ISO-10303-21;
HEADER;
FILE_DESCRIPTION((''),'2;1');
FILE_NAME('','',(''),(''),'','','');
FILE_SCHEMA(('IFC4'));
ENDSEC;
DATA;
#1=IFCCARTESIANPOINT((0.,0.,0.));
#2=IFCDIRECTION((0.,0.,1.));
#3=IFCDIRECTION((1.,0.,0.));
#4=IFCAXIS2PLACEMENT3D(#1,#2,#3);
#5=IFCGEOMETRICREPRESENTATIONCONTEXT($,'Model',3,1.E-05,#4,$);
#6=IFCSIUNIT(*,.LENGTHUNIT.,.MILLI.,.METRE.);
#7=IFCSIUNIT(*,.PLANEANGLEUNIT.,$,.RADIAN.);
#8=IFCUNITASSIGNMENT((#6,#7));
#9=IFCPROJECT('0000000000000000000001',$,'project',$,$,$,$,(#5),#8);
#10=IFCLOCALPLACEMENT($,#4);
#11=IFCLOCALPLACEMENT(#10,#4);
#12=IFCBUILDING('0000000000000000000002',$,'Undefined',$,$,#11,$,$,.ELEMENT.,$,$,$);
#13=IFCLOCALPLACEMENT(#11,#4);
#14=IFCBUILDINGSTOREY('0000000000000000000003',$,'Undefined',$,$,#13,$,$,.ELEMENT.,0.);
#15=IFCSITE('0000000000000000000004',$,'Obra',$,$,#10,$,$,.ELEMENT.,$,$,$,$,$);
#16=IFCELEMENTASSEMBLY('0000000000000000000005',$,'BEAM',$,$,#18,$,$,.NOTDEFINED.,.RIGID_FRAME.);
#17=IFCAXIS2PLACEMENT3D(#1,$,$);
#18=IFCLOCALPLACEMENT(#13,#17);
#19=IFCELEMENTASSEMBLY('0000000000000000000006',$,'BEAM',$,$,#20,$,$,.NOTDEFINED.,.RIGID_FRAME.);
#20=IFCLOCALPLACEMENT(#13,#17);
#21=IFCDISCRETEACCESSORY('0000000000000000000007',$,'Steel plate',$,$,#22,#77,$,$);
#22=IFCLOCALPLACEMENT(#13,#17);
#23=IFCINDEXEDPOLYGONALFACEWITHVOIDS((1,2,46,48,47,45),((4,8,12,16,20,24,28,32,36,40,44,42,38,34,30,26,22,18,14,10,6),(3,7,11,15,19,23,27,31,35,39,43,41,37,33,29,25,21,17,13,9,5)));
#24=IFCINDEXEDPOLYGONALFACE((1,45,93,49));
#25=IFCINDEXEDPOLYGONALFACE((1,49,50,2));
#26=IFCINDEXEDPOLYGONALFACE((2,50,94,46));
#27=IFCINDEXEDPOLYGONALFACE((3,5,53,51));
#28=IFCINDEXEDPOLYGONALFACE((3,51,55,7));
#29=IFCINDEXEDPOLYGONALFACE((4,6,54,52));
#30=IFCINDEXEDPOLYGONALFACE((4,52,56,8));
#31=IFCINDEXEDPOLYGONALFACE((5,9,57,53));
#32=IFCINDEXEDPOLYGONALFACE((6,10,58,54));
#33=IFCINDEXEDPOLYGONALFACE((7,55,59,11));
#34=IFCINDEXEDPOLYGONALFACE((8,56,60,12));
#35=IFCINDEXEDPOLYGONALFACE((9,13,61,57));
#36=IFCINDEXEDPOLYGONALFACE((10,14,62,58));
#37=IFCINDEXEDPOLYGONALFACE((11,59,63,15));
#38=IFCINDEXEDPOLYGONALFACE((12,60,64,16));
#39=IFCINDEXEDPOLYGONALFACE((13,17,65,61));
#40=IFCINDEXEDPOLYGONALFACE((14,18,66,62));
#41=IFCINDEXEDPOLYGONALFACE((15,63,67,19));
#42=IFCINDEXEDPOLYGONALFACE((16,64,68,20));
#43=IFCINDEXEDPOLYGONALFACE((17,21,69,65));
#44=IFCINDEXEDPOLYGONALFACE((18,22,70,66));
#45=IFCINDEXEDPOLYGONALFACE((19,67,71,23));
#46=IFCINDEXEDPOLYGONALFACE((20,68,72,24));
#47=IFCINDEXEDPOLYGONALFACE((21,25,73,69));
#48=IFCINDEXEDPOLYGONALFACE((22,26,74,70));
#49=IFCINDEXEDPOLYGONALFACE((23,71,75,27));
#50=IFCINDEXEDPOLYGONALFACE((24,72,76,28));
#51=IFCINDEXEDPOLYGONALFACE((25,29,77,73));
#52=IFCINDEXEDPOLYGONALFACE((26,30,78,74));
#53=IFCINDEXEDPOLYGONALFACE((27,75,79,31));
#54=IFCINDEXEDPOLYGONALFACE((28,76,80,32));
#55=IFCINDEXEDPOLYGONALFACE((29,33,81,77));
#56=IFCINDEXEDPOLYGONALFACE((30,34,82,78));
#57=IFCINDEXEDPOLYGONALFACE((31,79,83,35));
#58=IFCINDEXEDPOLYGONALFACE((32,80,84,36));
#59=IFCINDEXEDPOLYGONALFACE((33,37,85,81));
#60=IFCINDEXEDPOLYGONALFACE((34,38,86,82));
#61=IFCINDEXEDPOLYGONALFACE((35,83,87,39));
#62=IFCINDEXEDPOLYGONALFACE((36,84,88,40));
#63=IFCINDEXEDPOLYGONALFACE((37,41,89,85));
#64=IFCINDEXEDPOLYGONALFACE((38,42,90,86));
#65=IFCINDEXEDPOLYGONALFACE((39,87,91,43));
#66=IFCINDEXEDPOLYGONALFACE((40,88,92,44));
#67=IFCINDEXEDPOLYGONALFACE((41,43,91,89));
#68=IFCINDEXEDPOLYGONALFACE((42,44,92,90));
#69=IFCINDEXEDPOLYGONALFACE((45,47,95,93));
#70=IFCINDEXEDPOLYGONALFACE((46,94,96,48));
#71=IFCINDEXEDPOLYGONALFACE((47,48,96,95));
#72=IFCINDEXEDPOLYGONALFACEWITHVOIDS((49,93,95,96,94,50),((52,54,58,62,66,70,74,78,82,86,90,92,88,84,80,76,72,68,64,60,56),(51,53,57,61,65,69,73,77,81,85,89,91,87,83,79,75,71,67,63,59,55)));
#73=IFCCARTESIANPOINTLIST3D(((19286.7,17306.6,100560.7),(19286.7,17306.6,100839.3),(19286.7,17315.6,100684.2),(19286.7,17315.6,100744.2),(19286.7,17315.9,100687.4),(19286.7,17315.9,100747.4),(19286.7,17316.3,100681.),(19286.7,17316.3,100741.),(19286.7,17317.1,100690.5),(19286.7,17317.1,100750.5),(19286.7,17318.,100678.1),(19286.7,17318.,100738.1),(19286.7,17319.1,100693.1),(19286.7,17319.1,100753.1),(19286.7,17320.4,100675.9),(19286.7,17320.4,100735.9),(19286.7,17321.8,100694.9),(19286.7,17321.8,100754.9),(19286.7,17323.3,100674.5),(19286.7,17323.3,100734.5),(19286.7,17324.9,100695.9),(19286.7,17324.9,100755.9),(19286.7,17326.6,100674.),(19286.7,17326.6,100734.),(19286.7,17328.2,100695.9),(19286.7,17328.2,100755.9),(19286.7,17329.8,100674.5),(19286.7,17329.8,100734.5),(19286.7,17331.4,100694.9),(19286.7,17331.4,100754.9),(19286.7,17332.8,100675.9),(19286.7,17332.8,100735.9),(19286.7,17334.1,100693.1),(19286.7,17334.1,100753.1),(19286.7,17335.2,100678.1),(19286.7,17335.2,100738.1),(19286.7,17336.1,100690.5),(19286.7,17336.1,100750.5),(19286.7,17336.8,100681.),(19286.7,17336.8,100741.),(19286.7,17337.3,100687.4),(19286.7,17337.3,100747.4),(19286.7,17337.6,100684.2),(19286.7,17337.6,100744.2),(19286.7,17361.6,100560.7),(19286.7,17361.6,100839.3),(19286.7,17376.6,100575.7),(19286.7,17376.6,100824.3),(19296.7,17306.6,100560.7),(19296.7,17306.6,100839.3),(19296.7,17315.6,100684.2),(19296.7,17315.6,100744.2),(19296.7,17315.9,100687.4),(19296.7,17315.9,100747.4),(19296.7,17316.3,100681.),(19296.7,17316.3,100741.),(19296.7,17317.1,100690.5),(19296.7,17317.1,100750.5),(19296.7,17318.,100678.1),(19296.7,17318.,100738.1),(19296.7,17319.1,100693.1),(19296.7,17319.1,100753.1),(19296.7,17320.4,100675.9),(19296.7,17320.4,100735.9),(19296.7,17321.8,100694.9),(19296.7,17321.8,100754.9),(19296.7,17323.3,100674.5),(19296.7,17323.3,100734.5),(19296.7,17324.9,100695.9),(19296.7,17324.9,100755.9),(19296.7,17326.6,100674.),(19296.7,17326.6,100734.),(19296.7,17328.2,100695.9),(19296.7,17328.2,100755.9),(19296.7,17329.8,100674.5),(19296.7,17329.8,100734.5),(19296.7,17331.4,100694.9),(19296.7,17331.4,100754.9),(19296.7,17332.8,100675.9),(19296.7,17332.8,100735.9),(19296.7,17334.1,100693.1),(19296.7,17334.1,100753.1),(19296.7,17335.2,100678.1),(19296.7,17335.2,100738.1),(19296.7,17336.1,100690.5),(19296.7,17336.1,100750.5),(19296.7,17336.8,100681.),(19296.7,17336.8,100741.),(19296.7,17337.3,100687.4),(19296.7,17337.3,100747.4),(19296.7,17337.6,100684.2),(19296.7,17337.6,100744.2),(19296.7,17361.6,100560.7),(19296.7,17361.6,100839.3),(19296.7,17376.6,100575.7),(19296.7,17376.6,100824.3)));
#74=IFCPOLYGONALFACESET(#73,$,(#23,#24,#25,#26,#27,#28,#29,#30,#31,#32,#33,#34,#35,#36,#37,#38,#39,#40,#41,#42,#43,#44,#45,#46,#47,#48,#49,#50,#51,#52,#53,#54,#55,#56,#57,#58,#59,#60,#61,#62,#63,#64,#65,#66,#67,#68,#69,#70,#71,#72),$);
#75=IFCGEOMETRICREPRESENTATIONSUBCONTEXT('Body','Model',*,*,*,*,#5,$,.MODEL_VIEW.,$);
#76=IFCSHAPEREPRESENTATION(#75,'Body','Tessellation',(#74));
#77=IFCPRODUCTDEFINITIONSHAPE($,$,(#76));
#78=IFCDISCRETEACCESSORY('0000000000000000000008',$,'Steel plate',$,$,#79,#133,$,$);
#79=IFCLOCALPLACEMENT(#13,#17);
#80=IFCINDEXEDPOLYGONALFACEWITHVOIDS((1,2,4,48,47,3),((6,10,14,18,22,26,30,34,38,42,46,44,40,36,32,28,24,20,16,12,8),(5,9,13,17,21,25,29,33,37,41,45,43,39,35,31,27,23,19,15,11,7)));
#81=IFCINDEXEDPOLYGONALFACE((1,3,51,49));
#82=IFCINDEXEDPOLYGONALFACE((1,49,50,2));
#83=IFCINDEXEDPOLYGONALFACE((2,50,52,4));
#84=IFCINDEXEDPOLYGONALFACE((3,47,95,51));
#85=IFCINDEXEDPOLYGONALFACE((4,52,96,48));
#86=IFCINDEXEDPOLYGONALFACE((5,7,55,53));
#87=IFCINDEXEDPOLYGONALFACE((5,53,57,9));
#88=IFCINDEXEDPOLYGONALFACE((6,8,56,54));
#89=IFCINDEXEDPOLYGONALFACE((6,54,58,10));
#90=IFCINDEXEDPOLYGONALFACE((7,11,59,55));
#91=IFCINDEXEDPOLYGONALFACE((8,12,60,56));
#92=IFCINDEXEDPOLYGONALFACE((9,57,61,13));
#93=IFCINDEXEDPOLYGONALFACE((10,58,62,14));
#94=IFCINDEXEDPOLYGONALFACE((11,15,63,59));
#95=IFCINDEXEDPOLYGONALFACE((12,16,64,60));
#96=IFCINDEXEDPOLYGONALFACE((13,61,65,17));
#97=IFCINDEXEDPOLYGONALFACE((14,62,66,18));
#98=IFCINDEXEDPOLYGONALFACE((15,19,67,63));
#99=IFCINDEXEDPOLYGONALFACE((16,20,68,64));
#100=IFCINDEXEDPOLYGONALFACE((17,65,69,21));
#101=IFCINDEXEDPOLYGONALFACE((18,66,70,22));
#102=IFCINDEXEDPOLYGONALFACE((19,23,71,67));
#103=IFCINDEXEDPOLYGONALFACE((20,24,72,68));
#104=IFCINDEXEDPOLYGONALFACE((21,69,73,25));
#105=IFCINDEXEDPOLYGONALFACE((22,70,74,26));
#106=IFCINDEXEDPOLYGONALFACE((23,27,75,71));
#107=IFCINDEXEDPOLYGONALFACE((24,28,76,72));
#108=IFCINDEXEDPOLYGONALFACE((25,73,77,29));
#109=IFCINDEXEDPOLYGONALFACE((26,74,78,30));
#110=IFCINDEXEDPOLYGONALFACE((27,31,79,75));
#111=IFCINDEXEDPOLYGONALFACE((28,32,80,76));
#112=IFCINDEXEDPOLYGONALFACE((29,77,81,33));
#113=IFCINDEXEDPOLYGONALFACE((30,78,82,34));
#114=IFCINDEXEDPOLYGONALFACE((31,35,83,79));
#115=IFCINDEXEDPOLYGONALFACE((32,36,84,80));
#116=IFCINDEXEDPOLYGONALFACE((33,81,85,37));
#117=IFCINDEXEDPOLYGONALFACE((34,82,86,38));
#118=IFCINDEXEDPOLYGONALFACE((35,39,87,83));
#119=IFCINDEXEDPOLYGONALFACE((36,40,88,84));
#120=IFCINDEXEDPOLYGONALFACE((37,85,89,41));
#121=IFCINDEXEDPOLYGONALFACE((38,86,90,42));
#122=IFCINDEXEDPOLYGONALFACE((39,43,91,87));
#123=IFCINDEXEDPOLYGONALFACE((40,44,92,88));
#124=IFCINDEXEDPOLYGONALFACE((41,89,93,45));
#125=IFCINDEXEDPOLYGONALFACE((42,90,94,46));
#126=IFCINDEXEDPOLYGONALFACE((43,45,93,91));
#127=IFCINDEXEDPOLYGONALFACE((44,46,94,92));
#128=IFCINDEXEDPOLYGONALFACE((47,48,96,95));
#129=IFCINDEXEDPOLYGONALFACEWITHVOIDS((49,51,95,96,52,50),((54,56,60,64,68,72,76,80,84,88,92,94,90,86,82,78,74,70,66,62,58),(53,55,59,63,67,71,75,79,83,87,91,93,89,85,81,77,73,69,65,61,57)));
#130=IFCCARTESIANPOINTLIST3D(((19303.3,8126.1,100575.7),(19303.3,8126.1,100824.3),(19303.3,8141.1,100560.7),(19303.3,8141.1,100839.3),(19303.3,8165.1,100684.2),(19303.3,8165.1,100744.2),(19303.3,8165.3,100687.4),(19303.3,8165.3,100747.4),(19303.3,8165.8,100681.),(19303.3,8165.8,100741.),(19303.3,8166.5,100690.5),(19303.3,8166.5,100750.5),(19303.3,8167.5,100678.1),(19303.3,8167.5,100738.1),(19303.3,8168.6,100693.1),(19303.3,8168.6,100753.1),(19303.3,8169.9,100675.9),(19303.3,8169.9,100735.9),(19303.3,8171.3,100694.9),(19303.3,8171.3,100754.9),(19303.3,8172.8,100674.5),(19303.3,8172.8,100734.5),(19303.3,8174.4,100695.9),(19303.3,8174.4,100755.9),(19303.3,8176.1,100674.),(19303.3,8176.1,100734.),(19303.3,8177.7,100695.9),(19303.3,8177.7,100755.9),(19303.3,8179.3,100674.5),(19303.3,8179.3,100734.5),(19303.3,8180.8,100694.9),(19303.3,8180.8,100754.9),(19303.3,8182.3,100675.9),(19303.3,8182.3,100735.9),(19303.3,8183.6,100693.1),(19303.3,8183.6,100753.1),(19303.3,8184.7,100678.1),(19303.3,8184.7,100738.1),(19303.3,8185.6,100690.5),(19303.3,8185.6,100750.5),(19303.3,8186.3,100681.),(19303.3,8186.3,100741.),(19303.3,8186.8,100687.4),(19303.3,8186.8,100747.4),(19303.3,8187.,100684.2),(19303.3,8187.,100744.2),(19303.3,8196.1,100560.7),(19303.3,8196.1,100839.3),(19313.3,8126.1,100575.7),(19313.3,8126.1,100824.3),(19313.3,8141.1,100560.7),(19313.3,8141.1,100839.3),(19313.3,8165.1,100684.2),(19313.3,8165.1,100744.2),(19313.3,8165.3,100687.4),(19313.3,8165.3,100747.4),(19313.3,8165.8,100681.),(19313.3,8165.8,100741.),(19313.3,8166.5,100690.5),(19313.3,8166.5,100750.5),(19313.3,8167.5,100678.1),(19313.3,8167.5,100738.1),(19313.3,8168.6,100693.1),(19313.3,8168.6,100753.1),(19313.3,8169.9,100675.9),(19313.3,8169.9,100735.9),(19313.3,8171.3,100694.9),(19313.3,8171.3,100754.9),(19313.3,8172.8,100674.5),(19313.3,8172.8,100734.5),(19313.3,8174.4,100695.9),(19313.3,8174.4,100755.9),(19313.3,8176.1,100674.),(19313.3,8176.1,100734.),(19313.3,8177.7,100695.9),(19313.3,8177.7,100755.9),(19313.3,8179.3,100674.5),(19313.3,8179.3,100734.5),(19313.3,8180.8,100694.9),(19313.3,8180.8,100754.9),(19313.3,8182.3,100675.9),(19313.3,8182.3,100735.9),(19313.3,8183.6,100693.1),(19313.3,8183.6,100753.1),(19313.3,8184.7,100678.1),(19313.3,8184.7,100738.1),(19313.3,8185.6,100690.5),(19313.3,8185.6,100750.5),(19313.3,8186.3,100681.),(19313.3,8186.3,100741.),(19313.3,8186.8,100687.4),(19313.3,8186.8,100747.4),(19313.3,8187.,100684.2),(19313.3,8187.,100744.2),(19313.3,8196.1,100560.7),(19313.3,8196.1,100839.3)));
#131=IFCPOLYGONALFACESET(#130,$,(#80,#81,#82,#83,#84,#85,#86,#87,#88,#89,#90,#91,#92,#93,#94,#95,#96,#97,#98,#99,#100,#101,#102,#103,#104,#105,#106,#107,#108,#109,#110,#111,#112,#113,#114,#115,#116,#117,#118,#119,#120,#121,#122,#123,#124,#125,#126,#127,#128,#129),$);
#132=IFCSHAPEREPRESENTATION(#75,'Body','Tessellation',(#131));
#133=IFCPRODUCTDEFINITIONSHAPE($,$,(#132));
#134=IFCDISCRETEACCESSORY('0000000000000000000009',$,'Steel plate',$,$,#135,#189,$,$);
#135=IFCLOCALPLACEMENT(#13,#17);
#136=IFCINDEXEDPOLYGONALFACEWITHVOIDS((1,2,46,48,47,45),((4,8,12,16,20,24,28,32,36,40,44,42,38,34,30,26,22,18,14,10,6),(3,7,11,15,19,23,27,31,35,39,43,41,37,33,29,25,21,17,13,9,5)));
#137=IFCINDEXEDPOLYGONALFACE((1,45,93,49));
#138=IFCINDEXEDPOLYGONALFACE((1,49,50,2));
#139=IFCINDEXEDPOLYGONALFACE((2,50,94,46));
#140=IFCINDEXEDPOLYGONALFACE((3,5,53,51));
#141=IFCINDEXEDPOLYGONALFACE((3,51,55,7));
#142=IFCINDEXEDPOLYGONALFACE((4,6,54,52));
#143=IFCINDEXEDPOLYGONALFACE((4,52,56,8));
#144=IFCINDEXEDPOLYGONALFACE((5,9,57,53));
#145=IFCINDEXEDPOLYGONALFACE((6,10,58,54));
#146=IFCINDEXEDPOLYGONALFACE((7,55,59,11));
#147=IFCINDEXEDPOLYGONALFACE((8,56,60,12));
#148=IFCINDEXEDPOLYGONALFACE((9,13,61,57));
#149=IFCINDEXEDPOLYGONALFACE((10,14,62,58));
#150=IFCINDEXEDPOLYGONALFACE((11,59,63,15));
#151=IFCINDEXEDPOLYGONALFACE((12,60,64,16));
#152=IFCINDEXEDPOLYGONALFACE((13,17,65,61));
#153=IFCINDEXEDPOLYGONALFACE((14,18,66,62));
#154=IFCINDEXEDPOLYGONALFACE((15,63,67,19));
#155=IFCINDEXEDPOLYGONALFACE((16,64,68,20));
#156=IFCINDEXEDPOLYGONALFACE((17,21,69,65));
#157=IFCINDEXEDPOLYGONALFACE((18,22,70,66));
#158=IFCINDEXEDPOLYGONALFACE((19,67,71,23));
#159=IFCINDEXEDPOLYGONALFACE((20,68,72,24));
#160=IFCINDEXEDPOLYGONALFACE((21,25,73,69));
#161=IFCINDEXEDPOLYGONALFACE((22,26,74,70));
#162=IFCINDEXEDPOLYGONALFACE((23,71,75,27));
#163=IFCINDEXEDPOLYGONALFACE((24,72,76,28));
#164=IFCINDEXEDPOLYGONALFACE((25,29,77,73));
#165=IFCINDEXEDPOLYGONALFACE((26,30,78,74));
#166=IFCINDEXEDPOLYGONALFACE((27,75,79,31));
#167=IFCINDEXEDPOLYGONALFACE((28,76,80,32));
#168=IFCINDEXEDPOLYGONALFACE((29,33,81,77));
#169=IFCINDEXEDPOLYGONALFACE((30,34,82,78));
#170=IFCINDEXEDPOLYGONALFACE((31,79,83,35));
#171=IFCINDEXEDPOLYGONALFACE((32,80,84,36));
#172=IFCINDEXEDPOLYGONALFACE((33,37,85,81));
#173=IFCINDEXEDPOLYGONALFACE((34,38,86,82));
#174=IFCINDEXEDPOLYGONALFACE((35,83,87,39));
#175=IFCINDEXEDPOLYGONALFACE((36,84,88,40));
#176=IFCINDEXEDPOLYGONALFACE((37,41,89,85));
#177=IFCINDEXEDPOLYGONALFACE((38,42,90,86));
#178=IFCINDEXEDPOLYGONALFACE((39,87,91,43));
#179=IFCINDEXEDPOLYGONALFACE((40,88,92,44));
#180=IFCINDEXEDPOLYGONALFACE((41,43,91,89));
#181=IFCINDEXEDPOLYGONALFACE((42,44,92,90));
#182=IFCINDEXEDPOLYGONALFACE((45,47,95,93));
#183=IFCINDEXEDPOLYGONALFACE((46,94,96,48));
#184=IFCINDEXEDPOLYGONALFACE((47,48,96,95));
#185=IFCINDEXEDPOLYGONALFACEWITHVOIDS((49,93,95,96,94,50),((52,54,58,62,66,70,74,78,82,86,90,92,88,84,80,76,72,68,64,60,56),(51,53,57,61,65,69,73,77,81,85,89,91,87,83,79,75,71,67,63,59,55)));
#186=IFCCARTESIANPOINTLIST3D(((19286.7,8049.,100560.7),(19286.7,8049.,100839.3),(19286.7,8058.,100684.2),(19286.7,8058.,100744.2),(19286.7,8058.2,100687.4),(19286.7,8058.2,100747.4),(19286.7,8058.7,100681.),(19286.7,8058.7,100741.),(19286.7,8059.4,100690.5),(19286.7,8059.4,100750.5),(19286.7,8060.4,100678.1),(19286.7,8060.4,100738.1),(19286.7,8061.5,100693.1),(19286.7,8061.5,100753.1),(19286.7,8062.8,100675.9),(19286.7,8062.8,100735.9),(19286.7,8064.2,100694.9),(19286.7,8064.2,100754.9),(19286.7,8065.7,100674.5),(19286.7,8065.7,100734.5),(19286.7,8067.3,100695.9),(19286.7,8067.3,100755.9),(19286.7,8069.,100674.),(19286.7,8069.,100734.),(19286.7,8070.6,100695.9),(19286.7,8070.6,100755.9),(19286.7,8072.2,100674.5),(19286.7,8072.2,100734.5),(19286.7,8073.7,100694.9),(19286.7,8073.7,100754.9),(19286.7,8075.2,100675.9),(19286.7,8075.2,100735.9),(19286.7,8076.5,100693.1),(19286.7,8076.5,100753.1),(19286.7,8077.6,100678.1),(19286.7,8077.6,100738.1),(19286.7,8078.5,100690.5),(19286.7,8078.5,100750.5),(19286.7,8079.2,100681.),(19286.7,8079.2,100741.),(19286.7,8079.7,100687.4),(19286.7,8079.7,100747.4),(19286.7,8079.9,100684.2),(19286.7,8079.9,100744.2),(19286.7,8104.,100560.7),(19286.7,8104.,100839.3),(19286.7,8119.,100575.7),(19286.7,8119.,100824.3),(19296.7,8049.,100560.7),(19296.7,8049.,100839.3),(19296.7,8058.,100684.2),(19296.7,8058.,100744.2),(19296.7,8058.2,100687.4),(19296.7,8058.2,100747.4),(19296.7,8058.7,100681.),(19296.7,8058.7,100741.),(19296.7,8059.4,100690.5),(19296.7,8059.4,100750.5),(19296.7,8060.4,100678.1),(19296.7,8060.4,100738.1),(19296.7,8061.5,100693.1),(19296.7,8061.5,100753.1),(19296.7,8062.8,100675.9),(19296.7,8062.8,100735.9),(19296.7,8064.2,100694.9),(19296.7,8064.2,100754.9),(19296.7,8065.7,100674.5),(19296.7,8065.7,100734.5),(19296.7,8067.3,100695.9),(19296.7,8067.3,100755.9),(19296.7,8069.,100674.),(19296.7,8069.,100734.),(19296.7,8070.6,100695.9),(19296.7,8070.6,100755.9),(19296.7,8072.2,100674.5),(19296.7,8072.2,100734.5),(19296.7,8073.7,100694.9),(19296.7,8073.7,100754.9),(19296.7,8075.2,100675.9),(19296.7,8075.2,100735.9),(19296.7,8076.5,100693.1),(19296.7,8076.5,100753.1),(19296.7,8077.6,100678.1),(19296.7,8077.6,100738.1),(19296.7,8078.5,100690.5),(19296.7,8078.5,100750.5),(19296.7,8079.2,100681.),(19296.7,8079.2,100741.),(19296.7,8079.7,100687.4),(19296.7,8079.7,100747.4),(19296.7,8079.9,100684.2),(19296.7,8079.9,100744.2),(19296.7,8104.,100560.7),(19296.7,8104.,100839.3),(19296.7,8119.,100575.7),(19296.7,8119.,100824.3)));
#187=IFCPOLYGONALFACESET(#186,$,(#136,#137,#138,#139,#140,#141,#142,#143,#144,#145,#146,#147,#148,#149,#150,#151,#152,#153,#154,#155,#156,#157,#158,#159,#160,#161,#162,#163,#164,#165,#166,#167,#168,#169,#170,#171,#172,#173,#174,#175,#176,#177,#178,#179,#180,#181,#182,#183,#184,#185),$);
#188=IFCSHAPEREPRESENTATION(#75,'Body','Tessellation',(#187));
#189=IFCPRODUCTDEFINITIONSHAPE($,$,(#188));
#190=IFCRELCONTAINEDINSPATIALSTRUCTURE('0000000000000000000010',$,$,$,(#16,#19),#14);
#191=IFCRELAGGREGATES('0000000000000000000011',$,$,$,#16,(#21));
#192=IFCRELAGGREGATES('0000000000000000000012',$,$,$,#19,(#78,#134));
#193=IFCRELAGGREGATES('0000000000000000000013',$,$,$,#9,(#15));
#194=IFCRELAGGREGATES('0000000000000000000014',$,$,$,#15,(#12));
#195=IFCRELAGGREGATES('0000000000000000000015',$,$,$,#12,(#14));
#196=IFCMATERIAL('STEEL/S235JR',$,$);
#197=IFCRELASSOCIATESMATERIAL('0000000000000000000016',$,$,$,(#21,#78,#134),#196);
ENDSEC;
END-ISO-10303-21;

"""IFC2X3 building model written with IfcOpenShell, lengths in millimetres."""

from ifc_helpers import new_model, si_unit, frame, origin_with_axes, origin_2d_with_axis, place, context, subcontext, project, spatial, polyline, circle, outline, extrude, source, transform, mapped, material, element, aggregate, save


model = new_model("IFC2X3")

# Units and contexts
model_context = context("Model", 3, precision=1e-05, world=origin_with_axes())
body_context = subcontext(model_context, "Body", "Model", "MODEL_VIEW")
ifc_project = project(units=[si_unit("LENGTHUNIT", "METRE", prefix="MILLI"), si_unit("PLANEANGLEUNIT", "RADIAN")], contexts=[model_context])

# Site, building, storey
site_placement = place(None, origin_with_axes())
site = spatial("IfcSite", under=ifc_project, at=site_placement, Name="Obra", CompositionType="ELEMENT")
building_placement = place(site_placement, origin_with_axes())
building = spatial("IfcBuilding", under=site, at=building_placement, Name="Undefined", CompositionType="ELEMENT")
storey_placement = place(building_placement, origin_with_axes())
storey = spatial("IfcBuildingStorey", under=building, at=storey_placement, Name="Undefined", CompositionType="ELEMENT", Elevation=0.0)

# Element assemblies
assembly_1_placement = place(storey_placement, origin_with_axes())
assembly_1 = element("IfcElementAssembly", 1, at=assembly_1_placement, inside=storey, Name="BEAM", AssemblyPlace="NOTDEFINED", PredefinedType="RIGID_FRAME")
ifc_material_1 = material(Name="STEEL/S235JR")
assembly_2_placement = place(storey_placement, origin_with_axes())
assembly_2 = element("IfcElementAssembly", 2, at=assembly_2_placement, inside=storey, Name="BEAM", AssemblyPlace="NOTDEFINED", PredefinedType="RIGID_FRAME")

# Discrete accessories, openings
shared_shape_1 = source(origin_with_axes(), body_context, "Body", "SweptSolid", [
    extrude(circle(Radius=11.0, at=origin_2d_with_axis()), frame((0.0, -13.4, 0.0), z_axis=(0.0, 1.0, 0.0), x_axis=(1.0, 0.0, 0.0)), (0.0, 0.0, 1.0), 10.2),
])
discrete_accessory_1_placement = place(assembly_1_placement, frame((19291.7, 17306.6, 100560.7), z_axis=(1.0, 0.0, 0.0), x_axis=(0.0, 1.0, 0.0)))
discrete_accessory_1 = element("IfcDiscreteAccessory", 3, at=discrete_accessory_1_placement, material=ifc_material_1, Name="Steel plate", context=body_context, shape_type="SweptSolid", body=[
    extrude(outline(polyline([(0.0, 0.0), (55.0, 0.0), (70.0, 15.0), (70.0, 263.6), (55.0, 278.6), (0.0, 278.6), (0.0, 0.0)])), frame((0.0, 0.0, -5.0), z_axis=(0.0, 0.0, 1.0), x_axis=(1.0, 0.0, 0.0)), (0.0, 0.0, 1.0), 10.0),
])
opening_1_placement = place(assembly_1_placement, frame((19300.0, 17366.6, 100850.0), z_axis=(0.0, -1.0, 0.0), x_axis=(0.0, 0.0, -1.0)))
element("IfcOpeningElement", 4, at=opening_1_placement, cuts=discrete_accessory_1, ObjectType="Opening", context=body_context, shape_type="MappedRepresentation", body=[
    mapped(shared_shape_1, transform((105.0, 0.0, 40.0))),
    mapped(shared_shape_1, transform((165.0, 0.0, 40.0))),
])
aggregate(assembly_1, [discrete_accessory_1])
discrete_accessory_2_placement = place(assembly_2_placement, frame((19308.3, 8196.1, 100560.7), z_axis=(-1.0, 0.0, 0.0), x_axis=(0.0, -1.0, 0.0)))
discrete_accessory_2 = element("IfcDiscreteAccessory", 5, at=discrete_accessory_2_placement, material=ifc_material_1, Name="Steel plate", context=body_context, shape_type="SweptSolid", body=[
    extrude(outline(polyline([(0.0, 0.0), (55.0, 0.0), (70.0, 15.0), (70.0, 263.6), (55.0, 278.6), (0.0, 278.6), (0.0, 0.0)])), frame((0.0, 0.0, -5.0), z_axis=(0.0, 0.0, 1.0), x_axis=(1.0, 0.0, 0.0)), (0.0, 0.0, 1.0), 10.0),
])
opening_2_placement = place(assembly_2_placement, frame((19300.0, 8136.1, 100850.0), z_axis=(0.0, 1.0, 0.0), x_axis=(0.0, 0.0, -1.0)))
element("IfcOpeningElement", 6, at=opening_2_placement, cuts=discrete_accessory_2, ObjectType="Opening", context=body_context, shape_type="MappedRepresentation", body=[
    mapped(shared_shape_1, transform((105.0, 0.0, 40.0))),
    mapped(shared_shape_1, transform((165.0, 0.0, 40.0))),
])
discrete_accessory_3_placement = place(assembly_2_placement, frame((19291.7, 8049.0, 100560.7), z_axis=(1.0, 0.0, 0.0), x_axis=(0.0, 1.0, 0.0)))
discrete_accessory_3 = element("IfcDiscreteAccessory", 7, at=discrete_accessory_3_placement, material=ifc_material_1, Name="Steel plate", context=body_context, shape_type="SweptSolid", body=[
    extrude(outline(polyline([(0.0, 0.0), (55.0, 0.0), (70.0, 15.0), (70.0, 263.6), (55.0, 278.6), (0.0, 278.6), (0.0, 0.0)])), frame((0.0, 0.0, -5.0), z_axis=(0.0, 0.0, 1.0), x_axis=(1.0, 0.0, 0.0)), (0.0, 0.0, 1.0), 10.0),
])
opening_3_placement = place(assembly_2_placement, frame((19300.0, 8109.0, 100850.0), z_axis=(0.0, -1.0, 0.0), x_axis=(0.0, 0.0, -1.0)))
element("IfcOpeningElement", 8, at=opening_3_placement, cuts=discrete_accessory_3, ObjectType="Opening", context=body_context, shape_type="MappedRepresentation", body=[
    mapped(shared_shape_1, transform((105.0, 0.0, 40.0))),
    mapped(shared_shape_1, transform((165.0, 0.0, 40.0))),
])
aggregate(assembly_2, [discrete_accessory_2, discrete_accessory_3])

save(model, "model.ifc")
